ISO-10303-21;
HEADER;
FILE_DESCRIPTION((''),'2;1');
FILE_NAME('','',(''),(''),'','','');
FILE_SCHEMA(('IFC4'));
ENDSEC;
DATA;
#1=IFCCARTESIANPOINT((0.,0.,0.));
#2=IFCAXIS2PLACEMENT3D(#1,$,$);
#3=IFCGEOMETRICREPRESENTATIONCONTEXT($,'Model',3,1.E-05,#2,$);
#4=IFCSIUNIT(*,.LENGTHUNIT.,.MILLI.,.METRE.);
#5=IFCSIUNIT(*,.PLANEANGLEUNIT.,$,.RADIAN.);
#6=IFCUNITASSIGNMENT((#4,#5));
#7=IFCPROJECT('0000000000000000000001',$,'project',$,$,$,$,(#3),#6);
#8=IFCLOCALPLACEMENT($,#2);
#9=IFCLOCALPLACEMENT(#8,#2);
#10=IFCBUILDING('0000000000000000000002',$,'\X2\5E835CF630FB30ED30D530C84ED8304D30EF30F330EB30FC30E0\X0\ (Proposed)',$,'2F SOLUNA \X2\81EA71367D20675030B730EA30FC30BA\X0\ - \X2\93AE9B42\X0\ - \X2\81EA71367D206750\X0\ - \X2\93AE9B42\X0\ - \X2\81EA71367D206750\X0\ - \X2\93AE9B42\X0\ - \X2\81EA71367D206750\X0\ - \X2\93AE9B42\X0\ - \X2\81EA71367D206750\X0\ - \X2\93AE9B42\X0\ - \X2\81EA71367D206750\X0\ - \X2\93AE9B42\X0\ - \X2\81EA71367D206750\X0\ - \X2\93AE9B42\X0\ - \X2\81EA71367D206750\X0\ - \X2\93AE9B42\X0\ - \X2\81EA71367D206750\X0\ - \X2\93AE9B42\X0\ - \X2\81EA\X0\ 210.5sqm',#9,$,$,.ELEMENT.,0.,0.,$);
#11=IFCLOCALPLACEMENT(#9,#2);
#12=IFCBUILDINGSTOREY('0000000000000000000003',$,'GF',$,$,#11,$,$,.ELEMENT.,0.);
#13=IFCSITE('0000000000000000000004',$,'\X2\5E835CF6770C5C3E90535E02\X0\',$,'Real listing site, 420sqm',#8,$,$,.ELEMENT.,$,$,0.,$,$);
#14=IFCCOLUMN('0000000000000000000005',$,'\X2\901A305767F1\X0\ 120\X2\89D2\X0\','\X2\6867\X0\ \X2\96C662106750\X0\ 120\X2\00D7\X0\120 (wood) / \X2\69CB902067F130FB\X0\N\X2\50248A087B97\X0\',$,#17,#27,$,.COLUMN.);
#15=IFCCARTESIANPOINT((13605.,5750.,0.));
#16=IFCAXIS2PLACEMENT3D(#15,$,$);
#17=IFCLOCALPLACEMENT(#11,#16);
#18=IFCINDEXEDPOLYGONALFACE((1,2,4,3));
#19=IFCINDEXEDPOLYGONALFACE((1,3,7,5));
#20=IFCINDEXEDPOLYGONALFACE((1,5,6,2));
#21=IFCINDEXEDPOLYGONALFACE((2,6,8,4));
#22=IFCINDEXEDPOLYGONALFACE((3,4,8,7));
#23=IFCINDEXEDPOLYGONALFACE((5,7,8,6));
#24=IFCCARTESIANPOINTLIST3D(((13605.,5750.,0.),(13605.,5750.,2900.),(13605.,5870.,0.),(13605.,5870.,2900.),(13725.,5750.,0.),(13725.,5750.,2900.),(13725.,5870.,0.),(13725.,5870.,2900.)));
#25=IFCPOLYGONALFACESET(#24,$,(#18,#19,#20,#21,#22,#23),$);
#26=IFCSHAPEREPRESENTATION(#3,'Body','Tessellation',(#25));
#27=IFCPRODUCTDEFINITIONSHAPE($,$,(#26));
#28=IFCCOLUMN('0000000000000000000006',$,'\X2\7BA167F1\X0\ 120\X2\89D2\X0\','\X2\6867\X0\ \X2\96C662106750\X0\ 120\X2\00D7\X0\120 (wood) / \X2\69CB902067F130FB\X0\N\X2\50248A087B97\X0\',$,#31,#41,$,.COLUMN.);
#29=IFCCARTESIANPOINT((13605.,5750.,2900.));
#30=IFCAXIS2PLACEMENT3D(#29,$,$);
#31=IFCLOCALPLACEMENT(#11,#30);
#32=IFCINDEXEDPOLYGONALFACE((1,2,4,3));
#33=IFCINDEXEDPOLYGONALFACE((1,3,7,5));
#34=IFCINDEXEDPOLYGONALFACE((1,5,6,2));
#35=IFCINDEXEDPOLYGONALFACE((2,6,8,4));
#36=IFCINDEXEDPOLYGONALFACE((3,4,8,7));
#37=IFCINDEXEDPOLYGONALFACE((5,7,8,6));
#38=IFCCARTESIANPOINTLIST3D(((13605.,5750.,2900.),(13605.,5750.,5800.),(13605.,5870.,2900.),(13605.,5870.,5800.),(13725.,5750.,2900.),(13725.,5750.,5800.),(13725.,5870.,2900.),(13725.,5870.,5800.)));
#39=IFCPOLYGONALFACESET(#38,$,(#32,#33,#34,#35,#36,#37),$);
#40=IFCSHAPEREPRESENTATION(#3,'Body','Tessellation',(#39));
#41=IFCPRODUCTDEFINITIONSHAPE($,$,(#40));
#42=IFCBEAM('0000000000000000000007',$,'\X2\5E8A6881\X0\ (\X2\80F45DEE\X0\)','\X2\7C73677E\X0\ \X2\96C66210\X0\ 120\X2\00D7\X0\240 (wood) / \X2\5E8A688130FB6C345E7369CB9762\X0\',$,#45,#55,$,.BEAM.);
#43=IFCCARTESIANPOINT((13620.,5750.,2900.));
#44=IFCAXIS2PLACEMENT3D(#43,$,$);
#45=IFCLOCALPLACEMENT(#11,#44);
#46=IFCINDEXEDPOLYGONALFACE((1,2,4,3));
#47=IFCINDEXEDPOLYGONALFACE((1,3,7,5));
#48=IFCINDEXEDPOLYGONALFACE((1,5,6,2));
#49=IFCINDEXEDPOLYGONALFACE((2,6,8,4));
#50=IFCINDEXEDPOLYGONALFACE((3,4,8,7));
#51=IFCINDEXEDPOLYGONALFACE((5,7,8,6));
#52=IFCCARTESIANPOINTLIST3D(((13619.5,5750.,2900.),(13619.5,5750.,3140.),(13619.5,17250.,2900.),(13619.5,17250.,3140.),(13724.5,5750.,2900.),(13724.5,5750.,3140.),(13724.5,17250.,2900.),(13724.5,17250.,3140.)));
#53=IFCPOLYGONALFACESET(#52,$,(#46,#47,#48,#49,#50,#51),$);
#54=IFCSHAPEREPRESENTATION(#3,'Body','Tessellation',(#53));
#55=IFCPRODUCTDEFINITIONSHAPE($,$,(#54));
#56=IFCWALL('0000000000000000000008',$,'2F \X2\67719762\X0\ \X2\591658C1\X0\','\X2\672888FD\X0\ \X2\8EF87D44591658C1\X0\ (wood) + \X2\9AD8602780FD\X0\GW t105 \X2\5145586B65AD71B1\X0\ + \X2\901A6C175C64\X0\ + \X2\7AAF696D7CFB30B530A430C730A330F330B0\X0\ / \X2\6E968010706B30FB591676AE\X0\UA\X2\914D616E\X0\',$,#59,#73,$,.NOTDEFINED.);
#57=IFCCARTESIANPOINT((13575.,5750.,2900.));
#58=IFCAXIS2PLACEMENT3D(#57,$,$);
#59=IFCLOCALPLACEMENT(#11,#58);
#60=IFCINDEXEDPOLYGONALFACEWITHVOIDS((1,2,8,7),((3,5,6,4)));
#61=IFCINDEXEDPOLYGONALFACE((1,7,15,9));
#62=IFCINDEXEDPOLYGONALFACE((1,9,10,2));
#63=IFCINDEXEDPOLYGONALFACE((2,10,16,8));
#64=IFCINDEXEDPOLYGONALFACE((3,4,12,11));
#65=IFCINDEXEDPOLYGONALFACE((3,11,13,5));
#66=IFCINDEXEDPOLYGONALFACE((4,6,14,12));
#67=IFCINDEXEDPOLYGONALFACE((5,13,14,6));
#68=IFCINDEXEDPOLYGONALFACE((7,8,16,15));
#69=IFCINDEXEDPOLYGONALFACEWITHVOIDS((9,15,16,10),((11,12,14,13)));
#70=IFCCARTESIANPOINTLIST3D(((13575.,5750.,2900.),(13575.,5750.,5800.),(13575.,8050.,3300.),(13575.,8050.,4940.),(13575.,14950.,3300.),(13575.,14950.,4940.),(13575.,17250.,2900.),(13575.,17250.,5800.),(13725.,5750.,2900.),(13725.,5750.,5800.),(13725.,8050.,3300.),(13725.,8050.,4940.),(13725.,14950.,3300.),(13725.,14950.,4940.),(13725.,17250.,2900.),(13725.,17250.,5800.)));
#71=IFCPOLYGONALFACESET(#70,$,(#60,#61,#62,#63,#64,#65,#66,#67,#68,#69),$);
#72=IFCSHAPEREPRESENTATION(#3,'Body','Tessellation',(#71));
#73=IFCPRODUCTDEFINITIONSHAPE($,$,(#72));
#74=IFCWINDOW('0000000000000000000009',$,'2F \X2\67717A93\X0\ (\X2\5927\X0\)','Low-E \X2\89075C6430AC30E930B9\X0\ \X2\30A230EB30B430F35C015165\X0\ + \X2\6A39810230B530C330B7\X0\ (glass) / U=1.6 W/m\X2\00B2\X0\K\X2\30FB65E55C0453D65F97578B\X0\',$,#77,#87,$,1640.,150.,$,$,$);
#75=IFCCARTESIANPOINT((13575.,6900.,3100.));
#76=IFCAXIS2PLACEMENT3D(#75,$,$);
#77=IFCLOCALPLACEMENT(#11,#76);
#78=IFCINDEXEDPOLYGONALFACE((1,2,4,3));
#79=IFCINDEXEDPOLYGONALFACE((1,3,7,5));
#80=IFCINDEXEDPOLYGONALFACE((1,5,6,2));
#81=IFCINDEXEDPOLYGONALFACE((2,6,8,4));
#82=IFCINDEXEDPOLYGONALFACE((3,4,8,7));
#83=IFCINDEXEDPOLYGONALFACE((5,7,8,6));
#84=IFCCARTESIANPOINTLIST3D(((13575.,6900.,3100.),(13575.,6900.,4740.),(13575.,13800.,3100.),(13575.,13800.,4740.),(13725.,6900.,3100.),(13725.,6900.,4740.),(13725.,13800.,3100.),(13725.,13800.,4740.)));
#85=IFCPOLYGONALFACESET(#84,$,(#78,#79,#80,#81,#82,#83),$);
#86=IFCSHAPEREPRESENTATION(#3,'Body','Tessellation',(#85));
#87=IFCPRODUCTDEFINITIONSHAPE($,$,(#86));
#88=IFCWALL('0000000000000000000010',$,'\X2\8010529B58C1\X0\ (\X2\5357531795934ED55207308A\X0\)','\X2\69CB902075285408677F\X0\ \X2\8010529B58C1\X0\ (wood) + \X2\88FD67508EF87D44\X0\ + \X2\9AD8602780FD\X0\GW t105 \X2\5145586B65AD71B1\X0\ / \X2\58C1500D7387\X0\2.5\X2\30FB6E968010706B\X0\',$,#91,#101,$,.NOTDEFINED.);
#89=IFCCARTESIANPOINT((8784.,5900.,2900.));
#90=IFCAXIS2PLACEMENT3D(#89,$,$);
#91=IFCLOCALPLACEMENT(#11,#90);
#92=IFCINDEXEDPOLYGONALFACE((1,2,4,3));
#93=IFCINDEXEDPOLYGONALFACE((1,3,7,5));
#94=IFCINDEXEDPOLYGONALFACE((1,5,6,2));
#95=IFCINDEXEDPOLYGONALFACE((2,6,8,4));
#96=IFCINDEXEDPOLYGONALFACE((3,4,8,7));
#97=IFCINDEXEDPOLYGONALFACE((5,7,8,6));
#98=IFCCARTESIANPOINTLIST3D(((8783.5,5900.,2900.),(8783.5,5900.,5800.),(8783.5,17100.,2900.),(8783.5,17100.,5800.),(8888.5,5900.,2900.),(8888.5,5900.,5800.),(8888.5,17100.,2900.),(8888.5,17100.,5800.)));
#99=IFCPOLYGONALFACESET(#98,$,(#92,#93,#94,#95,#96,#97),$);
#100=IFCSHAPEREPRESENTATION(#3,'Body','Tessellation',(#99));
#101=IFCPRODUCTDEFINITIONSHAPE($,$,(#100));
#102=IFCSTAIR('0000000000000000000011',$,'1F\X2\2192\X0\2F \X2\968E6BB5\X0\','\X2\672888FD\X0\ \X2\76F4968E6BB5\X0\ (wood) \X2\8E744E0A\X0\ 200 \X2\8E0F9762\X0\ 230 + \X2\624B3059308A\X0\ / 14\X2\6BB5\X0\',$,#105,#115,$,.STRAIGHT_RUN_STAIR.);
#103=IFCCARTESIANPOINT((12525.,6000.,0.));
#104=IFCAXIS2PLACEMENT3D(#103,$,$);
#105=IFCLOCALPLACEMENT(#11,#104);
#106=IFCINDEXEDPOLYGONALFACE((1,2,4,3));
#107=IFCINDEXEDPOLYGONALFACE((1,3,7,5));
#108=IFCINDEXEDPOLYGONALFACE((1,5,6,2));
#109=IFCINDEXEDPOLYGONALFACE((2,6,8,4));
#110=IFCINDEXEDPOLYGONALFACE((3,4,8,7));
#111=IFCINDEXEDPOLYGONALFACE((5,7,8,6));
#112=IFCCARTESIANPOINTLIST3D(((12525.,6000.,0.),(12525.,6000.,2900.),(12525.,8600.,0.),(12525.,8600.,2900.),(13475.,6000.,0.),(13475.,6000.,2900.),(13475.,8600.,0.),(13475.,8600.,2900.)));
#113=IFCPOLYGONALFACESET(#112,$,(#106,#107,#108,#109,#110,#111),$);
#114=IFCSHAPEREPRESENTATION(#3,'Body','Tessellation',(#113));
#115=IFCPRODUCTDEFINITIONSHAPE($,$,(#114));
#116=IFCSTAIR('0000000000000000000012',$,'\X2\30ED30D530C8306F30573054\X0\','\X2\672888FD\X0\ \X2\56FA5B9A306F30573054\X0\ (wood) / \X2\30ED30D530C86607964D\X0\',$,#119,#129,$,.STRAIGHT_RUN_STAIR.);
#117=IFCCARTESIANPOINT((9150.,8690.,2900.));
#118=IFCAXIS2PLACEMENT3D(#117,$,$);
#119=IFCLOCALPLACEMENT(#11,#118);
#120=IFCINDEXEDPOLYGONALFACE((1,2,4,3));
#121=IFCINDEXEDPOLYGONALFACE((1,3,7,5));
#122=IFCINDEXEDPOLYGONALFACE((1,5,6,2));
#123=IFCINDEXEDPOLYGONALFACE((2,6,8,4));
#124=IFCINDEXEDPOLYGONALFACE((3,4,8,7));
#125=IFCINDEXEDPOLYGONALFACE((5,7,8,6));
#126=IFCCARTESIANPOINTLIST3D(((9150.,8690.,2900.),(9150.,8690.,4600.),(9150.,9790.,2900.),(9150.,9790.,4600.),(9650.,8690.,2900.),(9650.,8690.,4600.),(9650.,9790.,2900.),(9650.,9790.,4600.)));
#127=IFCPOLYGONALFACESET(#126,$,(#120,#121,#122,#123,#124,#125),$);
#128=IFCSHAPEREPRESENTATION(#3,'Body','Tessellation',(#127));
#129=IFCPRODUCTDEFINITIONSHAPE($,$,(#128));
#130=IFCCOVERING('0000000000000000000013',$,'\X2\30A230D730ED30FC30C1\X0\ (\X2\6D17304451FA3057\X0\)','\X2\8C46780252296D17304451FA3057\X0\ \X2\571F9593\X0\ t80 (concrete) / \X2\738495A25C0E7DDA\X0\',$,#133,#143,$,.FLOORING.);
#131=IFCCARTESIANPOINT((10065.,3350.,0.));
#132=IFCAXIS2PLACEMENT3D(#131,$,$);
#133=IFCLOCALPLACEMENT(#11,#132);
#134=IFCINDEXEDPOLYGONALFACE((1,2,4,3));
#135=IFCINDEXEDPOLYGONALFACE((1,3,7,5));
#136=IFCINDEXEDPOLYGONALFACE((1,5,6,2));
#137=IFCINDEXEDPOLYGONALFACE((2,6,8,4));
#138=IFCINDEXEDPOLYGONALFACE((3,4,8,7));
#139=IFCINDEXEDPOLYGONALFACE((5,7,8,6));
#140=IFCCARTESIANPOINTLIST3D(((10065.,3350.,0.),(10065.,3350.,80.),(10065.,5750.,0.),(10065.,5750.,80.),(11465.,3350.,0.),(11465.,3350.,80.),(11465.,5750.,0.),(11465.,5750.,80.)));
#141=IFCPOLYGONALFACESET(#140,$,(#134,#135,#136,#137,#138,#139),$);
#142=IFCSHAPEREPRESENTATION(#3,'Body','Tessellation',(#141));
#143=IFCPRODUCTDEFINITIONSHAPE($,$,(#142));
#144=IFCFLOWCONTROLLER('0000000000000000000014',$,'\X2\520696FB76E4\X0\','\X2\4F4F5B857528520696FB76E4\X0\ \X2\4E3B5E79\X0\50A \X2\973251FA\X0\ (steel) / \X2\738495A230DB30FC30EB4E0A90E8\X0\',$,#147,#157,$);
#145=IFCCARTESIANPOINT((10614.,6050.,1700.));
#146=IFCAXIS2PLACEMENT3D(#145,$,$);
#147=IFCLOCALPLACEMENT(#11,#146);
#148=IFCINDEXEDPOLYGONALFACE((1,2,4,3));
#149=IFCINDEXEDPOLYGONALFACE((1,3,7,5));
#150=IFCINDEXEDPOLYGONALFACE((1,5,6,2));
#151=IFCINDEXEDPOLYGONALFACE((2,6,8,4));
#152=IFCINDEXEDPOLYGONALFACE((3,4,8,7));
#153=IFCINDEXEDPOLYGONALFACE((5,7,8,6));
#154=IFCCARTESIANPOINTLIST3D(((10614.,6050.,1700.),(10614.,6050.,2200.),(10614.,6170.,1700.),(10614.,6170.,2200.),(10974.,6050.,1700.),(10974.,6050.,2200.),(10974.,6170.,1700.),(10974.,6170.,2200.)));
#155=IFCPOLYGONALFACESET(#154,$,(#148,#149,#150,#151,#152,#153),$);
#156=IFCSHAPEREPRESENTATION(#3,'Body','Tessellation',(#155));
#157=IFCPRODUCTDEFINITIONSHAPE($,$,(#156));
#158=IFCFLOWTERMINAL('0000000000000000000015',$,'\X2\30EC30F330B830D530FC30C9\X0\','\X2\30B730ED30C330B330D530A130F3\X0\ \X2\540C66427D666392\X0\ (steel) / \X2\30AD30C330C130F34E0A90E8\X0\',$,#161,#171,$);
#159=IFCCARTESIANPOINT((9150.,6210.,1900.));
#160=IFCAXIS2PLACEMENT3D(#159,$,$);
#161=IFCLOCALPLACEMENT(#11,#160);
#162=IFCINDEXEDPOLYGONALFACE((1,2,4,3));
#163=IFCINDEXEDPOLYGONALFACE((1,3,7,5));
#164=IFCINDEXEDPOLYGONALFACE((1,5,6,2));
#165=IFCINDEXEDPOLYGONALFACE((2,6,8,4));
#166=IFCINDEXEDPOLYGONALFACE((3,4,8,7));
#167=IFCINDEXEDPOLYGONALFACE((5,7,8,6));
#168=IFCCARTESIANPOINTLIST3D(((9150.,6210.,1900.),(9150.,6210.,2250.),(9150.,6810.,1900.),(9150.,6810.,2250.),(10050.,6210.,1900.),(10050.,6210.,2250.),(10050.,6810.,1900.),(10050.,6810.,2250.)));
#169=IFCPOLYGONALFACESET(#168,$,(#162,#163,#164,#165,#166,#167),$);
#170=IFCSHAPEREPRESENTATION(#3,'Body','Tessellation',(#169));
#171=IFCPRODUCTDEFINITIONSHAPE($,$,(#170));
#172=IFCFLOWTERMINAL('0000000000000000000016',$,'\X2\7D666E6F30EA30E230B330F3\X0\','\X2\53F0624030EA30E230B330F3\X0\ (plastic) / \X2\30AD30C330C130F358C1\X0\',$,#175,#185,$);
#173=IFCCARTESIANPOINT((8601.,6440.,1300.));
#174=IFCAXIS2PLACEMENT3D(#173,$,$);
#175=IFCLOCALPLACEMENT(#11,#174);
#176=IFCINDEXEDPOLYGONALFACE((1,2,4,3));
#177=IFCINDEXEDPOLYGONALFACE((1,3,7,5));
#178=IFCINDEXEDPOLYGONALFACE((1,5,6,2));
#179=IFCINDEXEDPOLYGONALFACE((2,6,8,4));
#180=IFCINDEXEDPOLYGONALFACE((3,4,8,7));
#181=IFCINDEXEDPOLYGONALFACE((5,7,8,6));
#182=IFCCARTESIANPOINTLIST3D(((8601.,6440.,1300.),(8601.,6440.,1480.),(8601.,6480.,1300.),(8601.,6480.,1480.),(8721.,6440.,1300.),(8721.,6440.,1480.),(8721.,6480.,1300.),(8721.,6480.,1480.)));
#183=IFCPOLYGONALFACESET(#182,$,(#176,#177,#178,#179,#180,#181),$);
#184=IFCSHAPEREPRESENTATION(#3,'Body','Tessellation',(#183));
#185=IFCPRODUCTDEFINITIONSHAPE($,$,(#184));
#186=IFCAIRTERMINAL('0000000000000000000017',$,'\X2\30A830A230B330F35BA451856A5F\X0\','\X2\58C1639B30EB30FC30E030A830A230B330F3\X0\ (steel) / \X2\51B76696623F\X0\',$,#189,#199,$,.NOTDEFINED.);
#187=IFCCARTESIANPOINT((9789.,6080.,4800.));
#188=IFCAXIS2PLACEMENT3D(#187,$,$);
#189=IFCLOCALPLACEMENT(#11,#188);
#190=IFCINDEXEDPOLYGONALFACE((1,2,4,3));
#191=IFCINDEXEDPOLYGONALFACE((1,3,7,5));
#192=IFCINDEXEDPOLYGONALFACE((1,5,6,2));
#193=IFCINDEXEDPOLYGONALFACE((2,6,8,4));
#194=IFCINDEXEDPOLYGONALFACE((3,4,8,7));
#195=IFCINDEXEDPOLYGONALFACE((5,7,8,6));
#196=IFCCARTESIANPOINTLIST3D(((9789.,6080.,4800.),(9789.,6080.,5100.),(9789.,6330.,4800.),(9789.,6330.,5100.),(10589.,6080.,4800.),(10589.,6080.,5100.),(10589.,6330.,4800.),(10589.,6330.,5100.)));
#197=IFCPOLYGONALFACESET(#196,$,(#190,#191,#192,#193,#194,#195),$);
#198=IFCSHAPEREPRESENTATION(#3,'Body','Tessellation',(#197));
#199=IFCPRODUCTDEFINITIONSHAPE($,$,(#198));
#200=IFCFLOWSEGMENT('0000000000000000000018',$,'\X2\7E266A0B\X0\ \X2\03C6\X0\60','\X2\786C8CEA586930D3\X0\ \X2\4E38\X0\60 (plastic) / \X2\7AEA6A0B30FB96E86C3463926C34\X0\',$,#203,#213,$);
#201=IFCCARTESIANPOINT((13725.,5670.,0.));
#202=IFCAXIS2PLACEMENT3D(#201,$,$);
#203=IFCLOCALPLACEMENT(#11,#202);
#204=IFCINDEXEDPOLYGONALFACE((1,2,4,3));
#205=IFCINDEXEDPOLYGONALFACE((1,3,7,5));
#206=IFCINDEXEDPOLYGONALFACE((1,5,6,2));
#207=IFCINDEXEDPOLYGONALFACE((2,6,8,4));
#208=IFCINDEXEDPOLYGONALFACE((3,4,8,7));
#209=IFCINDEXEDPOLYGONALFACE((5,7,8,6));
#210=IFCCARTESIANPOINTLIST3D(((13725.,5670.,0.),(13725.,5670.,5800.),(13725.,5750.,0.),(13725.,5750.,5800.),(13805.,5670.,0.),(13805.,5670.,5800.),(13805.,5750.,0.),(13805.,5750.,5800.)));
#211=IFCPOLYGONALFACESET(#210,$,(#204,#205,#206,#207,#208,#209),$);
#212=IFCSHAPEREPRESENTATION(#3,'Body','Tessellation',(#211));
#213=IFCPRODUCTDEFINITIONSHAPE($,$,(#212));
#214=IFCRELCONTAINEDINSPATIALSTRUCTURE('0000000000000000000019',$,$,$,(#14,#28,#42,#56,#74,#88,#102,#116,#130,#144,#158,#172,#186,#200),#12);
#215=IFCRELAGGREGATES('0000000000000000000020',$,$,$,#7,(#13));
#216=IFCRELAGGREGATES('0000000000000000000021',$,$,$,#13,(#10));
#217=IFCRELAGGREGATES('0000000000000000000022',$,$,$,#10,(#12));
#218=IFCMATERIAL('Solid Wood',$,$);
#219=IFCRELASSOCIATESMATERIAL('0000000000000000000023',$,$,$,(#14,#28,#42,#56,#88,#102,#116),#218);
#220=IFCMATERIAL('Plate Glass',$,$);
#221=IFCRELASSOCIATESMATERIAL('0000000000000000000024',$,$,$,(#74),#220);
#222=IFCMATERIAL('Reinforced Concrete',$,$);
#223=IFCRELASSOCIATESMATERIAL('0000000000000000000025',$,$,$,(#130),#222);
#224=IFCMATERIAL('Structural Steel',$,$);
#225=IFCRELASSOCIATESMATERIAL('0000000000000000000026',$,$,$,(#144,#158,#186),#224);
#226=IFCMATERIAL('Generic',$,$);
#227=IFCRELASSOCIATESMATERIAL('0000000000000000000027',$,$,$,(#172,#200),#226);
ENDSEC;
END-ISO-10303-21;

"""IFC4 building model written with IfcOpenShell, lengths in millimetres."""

from ifc_helpers import new_model, si_unit, frame, frame_2d, origin, place, context, project, spatial, rectangle, extrude, material, element, fill, save


model = new_model("IFC4")

# Units and contexts
model_context = context("Model", 3, precision=1e-05, world=origin())
ifc_project = project(units=[si_unit("LENGTHUNIT", "METRE", prefix="MILLI"), si_unit("PLANEANGLEUNIT", "RADIAN")], contexts=[model_context])

# Site, building, storey
site_placement = place(None, origin())
site = spatial("IfcSite", under=ifc_project, at=site_placement, Name="広島県尾道市", ObjectType="Real listing site, 420sqm", CompositionType="ELEMENT", RefElevation=0.0)
building_placement = place(site_placement, origin())
building = spatial("IfcBuilding", under=site, at=building_placement, Name="広島・ロフト付きワンルーム (Proposed)", ObjectType="2F SOLUNA 自然素材シリーズ - 鎮魂 - 自然素材 - 鎮魂 - 自然素材 - 鎮魂 - 自然素材 - 鎮魂 - 自然素材 - 鎮魂 - 自然素材 - 鎮魂 - 自然素材 - 鎮魂 - 自然素材 - 鎮魂 - 自然素材 - 鎮魂 - 自 210.5sqm", CompositionType="ELEMENT", ElevationOfRefHeight=0.0, ElevationOfTerrain=0.0)
storey_placement = place(building_placement, origin())
storey = spatial("IfcBuildingStorey", under=building, at=storey_placement, Name="GF", CompositionType="ELEMENT", Elevation=0.0)

# Columns
ifc_material_1 = material(Name="Solid Wood")
column_1_placement = place(storey_placement, frame((13605.0, 5750.0, 0.0)))
element("IfcColumn", 1, at=column_1_placement, inside=storey, material=ifc_material_1, Name="通し柱 120角", Description="桧 集成材 120×120 (wood) / 構造柱・N値計算", PredefinedType="COLUMN", context=model_context, shape_type="SweptSolid", body=[
    extrude(rectangle(XDim=120.0, YDim=120.0, at=frame_2d((60.0, 60.0))), frame((13605.0, 5750.0, 0.0)), (0.0, 0.0, 1.0), 2900.0),
])
column_2_placement = place(storey_placement, frame((13605.0, 5750.0, 2900.0)))
element("IfcColumn", 2, at=column_2_placement, inside=storey, material=ifc_material_1, Name="管柱 120角", Description="桧 集成材 120×120 (wood) / 構造柱・N値計算", PredefinedType="COLUMN", context=model_context, shape_type="SweptSolid", body=[
    extrude(rectangle(XDim=120.0, YDim=120.0, at=frame_2d((60.0, 60.0))), frame((13605.0, 5750.0, 2900.0)), (0.0, 0.0, 1.0), 2900.0),
])

# Beam
beam_1_placement = place(storey_placement, frame((13620.0, 5750.0, 2900.0)))
element("IfcBeam", 3, at=beam_1_placement, inside=storey, material=ifc_material_1, Name="床梁 (胴差)", Description="米松 集成 120×240 (wood) / 床梁・水平構面", PredefinedType="BEAM", context=model_context, shape_type="SweptSolid", body=[
    extrude(rectangle(XDim=105.0, YDim=11500.0, at=frame_2d((52.0, 5750.0))), frame((13620.0, 5750.0, 2900.0)), (0.0, 0.0, 1.0), 240.0),
])

# Shared definitions
ifc_material_2 = material(Name="Plate Glass")

# Wall, opening, window
wall_1_placement = place(storey_placement, frame((13575.0, 5750.0, 2900.0)))
wall_1 = element("IfcWall", 4, at=wall_1_placement, inside=storey, material=ifc_material_1, Name="2F 東面 外壁", Description="木製 軸組外壁 (wood) + 高性能GW t105 充填断熱 + 通気層 + 窯業系サイディング / 準耐火・外皮UA配慮", PredefinedType="NOTDEFINED", context=model_context, shape_type="SweptSolid", body=[
    extrude(rectangle(XDim=150.0, YDim=11500.0, at=frame_2d((75.0, 5750.0))), frame((13575.0, 5750.0, 2900.0)), (0.0, 0.0, 1.0), 2900.0),
])
opening_1_placement = place(storey_placement, frame((13575.0, 6900.0, 3100.0)))
opening_1 = element("IfcOpeningElement", 5, at=opening_1_placement, cuts=wall_1, PredefinedType="NOTDEFINED", context=model_context, shape_type="SweptSolid", body=[
    extrude(rectangle(XDim=150.0, YDim=6900.0, at=frame_2d((75.0, 3450.0))), frame((13575.0, 6900.0, 3100.0)), (0.0, 0.0, 1.0), 1640.0),
])
window_1_placement = place(storey_placement, frame((13575.0, 6900.0, 3100.0)))
window_1 = element("IfcWindow", 6, at=window_1_placement, inside=storey, material=ifc_material_2, Name="2F 東窓 (大)", Description="Low-E 複層ガラス アルゴン封入 + 樹脂サッシ (glass) / U=1.6 W/m²K・日射取得型", OverallHeight=1640.0, OverallWidth=150.0, context=model_context, shape_type="SweptSolid", body=[
    extrude(rectangle(XDim=150.0, YDim=6900.0, at=frame_2d((75.0, 3450.0))), frame((13575.0, 6900.0, 3100.0)), (0.0, 0.0, 1.0), 1640.0),
])
fill(opening_1, window_1)

# Wall
wall_2_placement = place(storey_placement, frame((8784.0, 5900.0, 2900.0)))
element("IfcWall", 7, at=wall_2_placement, inside=storey, material=ifc_material_1, Name="耐力壁 (南北間仕切り)", Description="構造用合板 耐力壁 (wood) + 製材軸組 + 高性能GW t105 充填断熱 / 壁倍率2.5・準耐火", PredefinedType="NOTDEFINED", context=model_context, shape_type="SweptSolid", body=[
    extrude(rectangle(XDim=105.0, YDim=11200.0, at=frame_2d((52.0, 5600.0))), frame((8784.0, 5900.0, 2900.0)), (0.0, 0.0, 1.0), 2900.0),
])

# Stairs
stair_1_placement = place(storey_placement, frame((12525.0, 6000.0, 0.0)))
element("IfcStair", 8, at=stair_1_placement, inside=storey, material=ifc_material_1, Name="1F→2F 階段", Description="木製 直階段 (wood) 蹴上 200 踏面 230 + 手すり / 14段", PredefinedType="STRAIGHT_RUN_STAIR", context=model_context, shape_type="SweptSolid", body=[
    extrude(rectangle(XDim=950.0, YDim=2600.0, at=frame_2d((475.0, 1300.0))), frame((12525.0, 6000.0, 0.0)), (0.0, 0.0, 1.0), 2900.0),
])
stair_2_placement = place(storey_placement, frame((9150.0, 8690.0, 2900.0)))
element("IfcStair", 9, at=stair_2_placement, inside=storey, material=ifc_material_1, Name="ロフトはしご", Description="木製 固定はしご (wood) / ロフト昇降", PredefinedType="STRAIGHT_RUN_STAIR", context=model_context, shape_type="SweptSolid", body=[
    extrude(rectangle(XDim=500.0, YDim=1100.0, at=frame_2d((250.0, 550.0))), frame((9150.0, 8690.0, 2900.0)), (0.0, 0.0, 1.0), 1700.0),
])

# Covering
ifc_material_3 = material(Name="Reinforced Concrete")
covering_placement = place(storey_placement, frame((10065.0, 3350.0, 0.0)))
element("IfcCovering", 10, at=covering_placement, inside=storey, material=ifc_material_3, Name="アプローチ (洗い出し)", Description="豆砂利洗い出し 土間 t80 (concrete) / 玄関導線", PredefinedType="FLOORING", context=model_context, shape_type="SweptSolid", body=[
    extrude(rectangle(XDim=1400.0, YDim=2400.0, at=frame_2d((700.0, 1200.0))), frame((10065.0, 3350.0, 0.0)), (0.0, 0.0, 1.0), 80.0),
])

# Flow controller
ifc_material_4 = material(Name="Structural Steel")
flow_controller_placement = place(storey_placement, frame((10614.0, 6050.0, 1700.0)))
element("IfcFlowController", 11, at=flow_controller_placement, inside=storey, material=ifc_material_4, Name="分電盤", Description="住宅用分電盤 主幹50A 露出 (steel) / 玄関ホール上部", context=model_context, shape_type="SweptSolid", body=[
    extrude(rectangle(XDim=360.0, YDim=120.0, at=frame_2d((180.0, 60.0))), frame((10614.0, 6050.0, 1700.0)), (0.0, 0.0, 1.0), 500.0),
])

# Flow terminals
flow_terminal_1_placement = place(storey_placement, frame((9150.0, 6210.0, 1900.0)))
element("IfcFlowTerminal", 12, at=flow_terminal_1_placement, inside=storey, material=ifc_material_4, Name="レンジフード", Description="シロッコファン 同時給排 (steel) / キッチン上部", context=model_context, shape_type="SweptSolid", body=[
    extrude(rectangle(XDim=900.0, YDim=600.0, at=frame_2d((450.0, 300.0))), frame((9150.0, 6210.0, 1900.0)), (0.0, 0.0, 1.0), 350.0),
])
ifc_material_5 = material(Name="Generic")
flow_terminal_2_placement = place(storey_placement, frame((8601.0, 6440.0, 1300.0)))
element("IfcFlowTerminal", 13, at=flow_terminal_2_placement, inside=storey, material=ifc_material_5, Name="給湯リモコン", Description="台所リモコン (plastic) / キッチン壁", context=model_context, shape_type="SweptSolid", body=[
    extrude(rectangle(XDim=120.0, YDim=40.0, at=frame_2d((60.0, 20.0))), frame((8601.0, 6440.0, 1300.0)), (0.0, 0.0, 1.0), 180.0),
])

# Air terminal
air_terminal_placement = place(storey_placement, frame((9789.0, 6080.0, 4800.0)))
element("IfcAirTerminal", 14, at=air_terminal_placement, inside=storey, material=ifc_material_4, Name="エアコン室内機", Description="壁掛ルームエアコン (steel) / 冷暖房", PredefinedType="NOTDEFINED", context=model_context, shape_type="SweptSolid", body=[
    extrude(rectangle(XDim=800.0, YDim=250.0, at=frame_2d((400.0, 125.0))), frame((9789.0, 6080.0, 4800.0)), (0.0, 0.0, 1.0), 300.0),
])

# Flow segment
flow_segment_placement = place(storey_placement, frame((13725.0, 5670.0, 0.0)))
element("IfcFlowSegment", 15, at=flow_segment_placement, inside=storey, material=ifc_material_5, Name="縦樋 φ60", Description="硬質塩ビ 丸60 (plastic) / 竪樋・雨水排水", context=model_context, shape_type="SweptSolid", body=[
    extrude(rectangle(XDim=80.0, YDim=80.0, at=frame_2d((40.0, 40.0))), frame((13725.0, 5670.0, 0.0)), (0.0, 0.0, 1.0), 5800.0),
])

save(model, "model.ifc")
